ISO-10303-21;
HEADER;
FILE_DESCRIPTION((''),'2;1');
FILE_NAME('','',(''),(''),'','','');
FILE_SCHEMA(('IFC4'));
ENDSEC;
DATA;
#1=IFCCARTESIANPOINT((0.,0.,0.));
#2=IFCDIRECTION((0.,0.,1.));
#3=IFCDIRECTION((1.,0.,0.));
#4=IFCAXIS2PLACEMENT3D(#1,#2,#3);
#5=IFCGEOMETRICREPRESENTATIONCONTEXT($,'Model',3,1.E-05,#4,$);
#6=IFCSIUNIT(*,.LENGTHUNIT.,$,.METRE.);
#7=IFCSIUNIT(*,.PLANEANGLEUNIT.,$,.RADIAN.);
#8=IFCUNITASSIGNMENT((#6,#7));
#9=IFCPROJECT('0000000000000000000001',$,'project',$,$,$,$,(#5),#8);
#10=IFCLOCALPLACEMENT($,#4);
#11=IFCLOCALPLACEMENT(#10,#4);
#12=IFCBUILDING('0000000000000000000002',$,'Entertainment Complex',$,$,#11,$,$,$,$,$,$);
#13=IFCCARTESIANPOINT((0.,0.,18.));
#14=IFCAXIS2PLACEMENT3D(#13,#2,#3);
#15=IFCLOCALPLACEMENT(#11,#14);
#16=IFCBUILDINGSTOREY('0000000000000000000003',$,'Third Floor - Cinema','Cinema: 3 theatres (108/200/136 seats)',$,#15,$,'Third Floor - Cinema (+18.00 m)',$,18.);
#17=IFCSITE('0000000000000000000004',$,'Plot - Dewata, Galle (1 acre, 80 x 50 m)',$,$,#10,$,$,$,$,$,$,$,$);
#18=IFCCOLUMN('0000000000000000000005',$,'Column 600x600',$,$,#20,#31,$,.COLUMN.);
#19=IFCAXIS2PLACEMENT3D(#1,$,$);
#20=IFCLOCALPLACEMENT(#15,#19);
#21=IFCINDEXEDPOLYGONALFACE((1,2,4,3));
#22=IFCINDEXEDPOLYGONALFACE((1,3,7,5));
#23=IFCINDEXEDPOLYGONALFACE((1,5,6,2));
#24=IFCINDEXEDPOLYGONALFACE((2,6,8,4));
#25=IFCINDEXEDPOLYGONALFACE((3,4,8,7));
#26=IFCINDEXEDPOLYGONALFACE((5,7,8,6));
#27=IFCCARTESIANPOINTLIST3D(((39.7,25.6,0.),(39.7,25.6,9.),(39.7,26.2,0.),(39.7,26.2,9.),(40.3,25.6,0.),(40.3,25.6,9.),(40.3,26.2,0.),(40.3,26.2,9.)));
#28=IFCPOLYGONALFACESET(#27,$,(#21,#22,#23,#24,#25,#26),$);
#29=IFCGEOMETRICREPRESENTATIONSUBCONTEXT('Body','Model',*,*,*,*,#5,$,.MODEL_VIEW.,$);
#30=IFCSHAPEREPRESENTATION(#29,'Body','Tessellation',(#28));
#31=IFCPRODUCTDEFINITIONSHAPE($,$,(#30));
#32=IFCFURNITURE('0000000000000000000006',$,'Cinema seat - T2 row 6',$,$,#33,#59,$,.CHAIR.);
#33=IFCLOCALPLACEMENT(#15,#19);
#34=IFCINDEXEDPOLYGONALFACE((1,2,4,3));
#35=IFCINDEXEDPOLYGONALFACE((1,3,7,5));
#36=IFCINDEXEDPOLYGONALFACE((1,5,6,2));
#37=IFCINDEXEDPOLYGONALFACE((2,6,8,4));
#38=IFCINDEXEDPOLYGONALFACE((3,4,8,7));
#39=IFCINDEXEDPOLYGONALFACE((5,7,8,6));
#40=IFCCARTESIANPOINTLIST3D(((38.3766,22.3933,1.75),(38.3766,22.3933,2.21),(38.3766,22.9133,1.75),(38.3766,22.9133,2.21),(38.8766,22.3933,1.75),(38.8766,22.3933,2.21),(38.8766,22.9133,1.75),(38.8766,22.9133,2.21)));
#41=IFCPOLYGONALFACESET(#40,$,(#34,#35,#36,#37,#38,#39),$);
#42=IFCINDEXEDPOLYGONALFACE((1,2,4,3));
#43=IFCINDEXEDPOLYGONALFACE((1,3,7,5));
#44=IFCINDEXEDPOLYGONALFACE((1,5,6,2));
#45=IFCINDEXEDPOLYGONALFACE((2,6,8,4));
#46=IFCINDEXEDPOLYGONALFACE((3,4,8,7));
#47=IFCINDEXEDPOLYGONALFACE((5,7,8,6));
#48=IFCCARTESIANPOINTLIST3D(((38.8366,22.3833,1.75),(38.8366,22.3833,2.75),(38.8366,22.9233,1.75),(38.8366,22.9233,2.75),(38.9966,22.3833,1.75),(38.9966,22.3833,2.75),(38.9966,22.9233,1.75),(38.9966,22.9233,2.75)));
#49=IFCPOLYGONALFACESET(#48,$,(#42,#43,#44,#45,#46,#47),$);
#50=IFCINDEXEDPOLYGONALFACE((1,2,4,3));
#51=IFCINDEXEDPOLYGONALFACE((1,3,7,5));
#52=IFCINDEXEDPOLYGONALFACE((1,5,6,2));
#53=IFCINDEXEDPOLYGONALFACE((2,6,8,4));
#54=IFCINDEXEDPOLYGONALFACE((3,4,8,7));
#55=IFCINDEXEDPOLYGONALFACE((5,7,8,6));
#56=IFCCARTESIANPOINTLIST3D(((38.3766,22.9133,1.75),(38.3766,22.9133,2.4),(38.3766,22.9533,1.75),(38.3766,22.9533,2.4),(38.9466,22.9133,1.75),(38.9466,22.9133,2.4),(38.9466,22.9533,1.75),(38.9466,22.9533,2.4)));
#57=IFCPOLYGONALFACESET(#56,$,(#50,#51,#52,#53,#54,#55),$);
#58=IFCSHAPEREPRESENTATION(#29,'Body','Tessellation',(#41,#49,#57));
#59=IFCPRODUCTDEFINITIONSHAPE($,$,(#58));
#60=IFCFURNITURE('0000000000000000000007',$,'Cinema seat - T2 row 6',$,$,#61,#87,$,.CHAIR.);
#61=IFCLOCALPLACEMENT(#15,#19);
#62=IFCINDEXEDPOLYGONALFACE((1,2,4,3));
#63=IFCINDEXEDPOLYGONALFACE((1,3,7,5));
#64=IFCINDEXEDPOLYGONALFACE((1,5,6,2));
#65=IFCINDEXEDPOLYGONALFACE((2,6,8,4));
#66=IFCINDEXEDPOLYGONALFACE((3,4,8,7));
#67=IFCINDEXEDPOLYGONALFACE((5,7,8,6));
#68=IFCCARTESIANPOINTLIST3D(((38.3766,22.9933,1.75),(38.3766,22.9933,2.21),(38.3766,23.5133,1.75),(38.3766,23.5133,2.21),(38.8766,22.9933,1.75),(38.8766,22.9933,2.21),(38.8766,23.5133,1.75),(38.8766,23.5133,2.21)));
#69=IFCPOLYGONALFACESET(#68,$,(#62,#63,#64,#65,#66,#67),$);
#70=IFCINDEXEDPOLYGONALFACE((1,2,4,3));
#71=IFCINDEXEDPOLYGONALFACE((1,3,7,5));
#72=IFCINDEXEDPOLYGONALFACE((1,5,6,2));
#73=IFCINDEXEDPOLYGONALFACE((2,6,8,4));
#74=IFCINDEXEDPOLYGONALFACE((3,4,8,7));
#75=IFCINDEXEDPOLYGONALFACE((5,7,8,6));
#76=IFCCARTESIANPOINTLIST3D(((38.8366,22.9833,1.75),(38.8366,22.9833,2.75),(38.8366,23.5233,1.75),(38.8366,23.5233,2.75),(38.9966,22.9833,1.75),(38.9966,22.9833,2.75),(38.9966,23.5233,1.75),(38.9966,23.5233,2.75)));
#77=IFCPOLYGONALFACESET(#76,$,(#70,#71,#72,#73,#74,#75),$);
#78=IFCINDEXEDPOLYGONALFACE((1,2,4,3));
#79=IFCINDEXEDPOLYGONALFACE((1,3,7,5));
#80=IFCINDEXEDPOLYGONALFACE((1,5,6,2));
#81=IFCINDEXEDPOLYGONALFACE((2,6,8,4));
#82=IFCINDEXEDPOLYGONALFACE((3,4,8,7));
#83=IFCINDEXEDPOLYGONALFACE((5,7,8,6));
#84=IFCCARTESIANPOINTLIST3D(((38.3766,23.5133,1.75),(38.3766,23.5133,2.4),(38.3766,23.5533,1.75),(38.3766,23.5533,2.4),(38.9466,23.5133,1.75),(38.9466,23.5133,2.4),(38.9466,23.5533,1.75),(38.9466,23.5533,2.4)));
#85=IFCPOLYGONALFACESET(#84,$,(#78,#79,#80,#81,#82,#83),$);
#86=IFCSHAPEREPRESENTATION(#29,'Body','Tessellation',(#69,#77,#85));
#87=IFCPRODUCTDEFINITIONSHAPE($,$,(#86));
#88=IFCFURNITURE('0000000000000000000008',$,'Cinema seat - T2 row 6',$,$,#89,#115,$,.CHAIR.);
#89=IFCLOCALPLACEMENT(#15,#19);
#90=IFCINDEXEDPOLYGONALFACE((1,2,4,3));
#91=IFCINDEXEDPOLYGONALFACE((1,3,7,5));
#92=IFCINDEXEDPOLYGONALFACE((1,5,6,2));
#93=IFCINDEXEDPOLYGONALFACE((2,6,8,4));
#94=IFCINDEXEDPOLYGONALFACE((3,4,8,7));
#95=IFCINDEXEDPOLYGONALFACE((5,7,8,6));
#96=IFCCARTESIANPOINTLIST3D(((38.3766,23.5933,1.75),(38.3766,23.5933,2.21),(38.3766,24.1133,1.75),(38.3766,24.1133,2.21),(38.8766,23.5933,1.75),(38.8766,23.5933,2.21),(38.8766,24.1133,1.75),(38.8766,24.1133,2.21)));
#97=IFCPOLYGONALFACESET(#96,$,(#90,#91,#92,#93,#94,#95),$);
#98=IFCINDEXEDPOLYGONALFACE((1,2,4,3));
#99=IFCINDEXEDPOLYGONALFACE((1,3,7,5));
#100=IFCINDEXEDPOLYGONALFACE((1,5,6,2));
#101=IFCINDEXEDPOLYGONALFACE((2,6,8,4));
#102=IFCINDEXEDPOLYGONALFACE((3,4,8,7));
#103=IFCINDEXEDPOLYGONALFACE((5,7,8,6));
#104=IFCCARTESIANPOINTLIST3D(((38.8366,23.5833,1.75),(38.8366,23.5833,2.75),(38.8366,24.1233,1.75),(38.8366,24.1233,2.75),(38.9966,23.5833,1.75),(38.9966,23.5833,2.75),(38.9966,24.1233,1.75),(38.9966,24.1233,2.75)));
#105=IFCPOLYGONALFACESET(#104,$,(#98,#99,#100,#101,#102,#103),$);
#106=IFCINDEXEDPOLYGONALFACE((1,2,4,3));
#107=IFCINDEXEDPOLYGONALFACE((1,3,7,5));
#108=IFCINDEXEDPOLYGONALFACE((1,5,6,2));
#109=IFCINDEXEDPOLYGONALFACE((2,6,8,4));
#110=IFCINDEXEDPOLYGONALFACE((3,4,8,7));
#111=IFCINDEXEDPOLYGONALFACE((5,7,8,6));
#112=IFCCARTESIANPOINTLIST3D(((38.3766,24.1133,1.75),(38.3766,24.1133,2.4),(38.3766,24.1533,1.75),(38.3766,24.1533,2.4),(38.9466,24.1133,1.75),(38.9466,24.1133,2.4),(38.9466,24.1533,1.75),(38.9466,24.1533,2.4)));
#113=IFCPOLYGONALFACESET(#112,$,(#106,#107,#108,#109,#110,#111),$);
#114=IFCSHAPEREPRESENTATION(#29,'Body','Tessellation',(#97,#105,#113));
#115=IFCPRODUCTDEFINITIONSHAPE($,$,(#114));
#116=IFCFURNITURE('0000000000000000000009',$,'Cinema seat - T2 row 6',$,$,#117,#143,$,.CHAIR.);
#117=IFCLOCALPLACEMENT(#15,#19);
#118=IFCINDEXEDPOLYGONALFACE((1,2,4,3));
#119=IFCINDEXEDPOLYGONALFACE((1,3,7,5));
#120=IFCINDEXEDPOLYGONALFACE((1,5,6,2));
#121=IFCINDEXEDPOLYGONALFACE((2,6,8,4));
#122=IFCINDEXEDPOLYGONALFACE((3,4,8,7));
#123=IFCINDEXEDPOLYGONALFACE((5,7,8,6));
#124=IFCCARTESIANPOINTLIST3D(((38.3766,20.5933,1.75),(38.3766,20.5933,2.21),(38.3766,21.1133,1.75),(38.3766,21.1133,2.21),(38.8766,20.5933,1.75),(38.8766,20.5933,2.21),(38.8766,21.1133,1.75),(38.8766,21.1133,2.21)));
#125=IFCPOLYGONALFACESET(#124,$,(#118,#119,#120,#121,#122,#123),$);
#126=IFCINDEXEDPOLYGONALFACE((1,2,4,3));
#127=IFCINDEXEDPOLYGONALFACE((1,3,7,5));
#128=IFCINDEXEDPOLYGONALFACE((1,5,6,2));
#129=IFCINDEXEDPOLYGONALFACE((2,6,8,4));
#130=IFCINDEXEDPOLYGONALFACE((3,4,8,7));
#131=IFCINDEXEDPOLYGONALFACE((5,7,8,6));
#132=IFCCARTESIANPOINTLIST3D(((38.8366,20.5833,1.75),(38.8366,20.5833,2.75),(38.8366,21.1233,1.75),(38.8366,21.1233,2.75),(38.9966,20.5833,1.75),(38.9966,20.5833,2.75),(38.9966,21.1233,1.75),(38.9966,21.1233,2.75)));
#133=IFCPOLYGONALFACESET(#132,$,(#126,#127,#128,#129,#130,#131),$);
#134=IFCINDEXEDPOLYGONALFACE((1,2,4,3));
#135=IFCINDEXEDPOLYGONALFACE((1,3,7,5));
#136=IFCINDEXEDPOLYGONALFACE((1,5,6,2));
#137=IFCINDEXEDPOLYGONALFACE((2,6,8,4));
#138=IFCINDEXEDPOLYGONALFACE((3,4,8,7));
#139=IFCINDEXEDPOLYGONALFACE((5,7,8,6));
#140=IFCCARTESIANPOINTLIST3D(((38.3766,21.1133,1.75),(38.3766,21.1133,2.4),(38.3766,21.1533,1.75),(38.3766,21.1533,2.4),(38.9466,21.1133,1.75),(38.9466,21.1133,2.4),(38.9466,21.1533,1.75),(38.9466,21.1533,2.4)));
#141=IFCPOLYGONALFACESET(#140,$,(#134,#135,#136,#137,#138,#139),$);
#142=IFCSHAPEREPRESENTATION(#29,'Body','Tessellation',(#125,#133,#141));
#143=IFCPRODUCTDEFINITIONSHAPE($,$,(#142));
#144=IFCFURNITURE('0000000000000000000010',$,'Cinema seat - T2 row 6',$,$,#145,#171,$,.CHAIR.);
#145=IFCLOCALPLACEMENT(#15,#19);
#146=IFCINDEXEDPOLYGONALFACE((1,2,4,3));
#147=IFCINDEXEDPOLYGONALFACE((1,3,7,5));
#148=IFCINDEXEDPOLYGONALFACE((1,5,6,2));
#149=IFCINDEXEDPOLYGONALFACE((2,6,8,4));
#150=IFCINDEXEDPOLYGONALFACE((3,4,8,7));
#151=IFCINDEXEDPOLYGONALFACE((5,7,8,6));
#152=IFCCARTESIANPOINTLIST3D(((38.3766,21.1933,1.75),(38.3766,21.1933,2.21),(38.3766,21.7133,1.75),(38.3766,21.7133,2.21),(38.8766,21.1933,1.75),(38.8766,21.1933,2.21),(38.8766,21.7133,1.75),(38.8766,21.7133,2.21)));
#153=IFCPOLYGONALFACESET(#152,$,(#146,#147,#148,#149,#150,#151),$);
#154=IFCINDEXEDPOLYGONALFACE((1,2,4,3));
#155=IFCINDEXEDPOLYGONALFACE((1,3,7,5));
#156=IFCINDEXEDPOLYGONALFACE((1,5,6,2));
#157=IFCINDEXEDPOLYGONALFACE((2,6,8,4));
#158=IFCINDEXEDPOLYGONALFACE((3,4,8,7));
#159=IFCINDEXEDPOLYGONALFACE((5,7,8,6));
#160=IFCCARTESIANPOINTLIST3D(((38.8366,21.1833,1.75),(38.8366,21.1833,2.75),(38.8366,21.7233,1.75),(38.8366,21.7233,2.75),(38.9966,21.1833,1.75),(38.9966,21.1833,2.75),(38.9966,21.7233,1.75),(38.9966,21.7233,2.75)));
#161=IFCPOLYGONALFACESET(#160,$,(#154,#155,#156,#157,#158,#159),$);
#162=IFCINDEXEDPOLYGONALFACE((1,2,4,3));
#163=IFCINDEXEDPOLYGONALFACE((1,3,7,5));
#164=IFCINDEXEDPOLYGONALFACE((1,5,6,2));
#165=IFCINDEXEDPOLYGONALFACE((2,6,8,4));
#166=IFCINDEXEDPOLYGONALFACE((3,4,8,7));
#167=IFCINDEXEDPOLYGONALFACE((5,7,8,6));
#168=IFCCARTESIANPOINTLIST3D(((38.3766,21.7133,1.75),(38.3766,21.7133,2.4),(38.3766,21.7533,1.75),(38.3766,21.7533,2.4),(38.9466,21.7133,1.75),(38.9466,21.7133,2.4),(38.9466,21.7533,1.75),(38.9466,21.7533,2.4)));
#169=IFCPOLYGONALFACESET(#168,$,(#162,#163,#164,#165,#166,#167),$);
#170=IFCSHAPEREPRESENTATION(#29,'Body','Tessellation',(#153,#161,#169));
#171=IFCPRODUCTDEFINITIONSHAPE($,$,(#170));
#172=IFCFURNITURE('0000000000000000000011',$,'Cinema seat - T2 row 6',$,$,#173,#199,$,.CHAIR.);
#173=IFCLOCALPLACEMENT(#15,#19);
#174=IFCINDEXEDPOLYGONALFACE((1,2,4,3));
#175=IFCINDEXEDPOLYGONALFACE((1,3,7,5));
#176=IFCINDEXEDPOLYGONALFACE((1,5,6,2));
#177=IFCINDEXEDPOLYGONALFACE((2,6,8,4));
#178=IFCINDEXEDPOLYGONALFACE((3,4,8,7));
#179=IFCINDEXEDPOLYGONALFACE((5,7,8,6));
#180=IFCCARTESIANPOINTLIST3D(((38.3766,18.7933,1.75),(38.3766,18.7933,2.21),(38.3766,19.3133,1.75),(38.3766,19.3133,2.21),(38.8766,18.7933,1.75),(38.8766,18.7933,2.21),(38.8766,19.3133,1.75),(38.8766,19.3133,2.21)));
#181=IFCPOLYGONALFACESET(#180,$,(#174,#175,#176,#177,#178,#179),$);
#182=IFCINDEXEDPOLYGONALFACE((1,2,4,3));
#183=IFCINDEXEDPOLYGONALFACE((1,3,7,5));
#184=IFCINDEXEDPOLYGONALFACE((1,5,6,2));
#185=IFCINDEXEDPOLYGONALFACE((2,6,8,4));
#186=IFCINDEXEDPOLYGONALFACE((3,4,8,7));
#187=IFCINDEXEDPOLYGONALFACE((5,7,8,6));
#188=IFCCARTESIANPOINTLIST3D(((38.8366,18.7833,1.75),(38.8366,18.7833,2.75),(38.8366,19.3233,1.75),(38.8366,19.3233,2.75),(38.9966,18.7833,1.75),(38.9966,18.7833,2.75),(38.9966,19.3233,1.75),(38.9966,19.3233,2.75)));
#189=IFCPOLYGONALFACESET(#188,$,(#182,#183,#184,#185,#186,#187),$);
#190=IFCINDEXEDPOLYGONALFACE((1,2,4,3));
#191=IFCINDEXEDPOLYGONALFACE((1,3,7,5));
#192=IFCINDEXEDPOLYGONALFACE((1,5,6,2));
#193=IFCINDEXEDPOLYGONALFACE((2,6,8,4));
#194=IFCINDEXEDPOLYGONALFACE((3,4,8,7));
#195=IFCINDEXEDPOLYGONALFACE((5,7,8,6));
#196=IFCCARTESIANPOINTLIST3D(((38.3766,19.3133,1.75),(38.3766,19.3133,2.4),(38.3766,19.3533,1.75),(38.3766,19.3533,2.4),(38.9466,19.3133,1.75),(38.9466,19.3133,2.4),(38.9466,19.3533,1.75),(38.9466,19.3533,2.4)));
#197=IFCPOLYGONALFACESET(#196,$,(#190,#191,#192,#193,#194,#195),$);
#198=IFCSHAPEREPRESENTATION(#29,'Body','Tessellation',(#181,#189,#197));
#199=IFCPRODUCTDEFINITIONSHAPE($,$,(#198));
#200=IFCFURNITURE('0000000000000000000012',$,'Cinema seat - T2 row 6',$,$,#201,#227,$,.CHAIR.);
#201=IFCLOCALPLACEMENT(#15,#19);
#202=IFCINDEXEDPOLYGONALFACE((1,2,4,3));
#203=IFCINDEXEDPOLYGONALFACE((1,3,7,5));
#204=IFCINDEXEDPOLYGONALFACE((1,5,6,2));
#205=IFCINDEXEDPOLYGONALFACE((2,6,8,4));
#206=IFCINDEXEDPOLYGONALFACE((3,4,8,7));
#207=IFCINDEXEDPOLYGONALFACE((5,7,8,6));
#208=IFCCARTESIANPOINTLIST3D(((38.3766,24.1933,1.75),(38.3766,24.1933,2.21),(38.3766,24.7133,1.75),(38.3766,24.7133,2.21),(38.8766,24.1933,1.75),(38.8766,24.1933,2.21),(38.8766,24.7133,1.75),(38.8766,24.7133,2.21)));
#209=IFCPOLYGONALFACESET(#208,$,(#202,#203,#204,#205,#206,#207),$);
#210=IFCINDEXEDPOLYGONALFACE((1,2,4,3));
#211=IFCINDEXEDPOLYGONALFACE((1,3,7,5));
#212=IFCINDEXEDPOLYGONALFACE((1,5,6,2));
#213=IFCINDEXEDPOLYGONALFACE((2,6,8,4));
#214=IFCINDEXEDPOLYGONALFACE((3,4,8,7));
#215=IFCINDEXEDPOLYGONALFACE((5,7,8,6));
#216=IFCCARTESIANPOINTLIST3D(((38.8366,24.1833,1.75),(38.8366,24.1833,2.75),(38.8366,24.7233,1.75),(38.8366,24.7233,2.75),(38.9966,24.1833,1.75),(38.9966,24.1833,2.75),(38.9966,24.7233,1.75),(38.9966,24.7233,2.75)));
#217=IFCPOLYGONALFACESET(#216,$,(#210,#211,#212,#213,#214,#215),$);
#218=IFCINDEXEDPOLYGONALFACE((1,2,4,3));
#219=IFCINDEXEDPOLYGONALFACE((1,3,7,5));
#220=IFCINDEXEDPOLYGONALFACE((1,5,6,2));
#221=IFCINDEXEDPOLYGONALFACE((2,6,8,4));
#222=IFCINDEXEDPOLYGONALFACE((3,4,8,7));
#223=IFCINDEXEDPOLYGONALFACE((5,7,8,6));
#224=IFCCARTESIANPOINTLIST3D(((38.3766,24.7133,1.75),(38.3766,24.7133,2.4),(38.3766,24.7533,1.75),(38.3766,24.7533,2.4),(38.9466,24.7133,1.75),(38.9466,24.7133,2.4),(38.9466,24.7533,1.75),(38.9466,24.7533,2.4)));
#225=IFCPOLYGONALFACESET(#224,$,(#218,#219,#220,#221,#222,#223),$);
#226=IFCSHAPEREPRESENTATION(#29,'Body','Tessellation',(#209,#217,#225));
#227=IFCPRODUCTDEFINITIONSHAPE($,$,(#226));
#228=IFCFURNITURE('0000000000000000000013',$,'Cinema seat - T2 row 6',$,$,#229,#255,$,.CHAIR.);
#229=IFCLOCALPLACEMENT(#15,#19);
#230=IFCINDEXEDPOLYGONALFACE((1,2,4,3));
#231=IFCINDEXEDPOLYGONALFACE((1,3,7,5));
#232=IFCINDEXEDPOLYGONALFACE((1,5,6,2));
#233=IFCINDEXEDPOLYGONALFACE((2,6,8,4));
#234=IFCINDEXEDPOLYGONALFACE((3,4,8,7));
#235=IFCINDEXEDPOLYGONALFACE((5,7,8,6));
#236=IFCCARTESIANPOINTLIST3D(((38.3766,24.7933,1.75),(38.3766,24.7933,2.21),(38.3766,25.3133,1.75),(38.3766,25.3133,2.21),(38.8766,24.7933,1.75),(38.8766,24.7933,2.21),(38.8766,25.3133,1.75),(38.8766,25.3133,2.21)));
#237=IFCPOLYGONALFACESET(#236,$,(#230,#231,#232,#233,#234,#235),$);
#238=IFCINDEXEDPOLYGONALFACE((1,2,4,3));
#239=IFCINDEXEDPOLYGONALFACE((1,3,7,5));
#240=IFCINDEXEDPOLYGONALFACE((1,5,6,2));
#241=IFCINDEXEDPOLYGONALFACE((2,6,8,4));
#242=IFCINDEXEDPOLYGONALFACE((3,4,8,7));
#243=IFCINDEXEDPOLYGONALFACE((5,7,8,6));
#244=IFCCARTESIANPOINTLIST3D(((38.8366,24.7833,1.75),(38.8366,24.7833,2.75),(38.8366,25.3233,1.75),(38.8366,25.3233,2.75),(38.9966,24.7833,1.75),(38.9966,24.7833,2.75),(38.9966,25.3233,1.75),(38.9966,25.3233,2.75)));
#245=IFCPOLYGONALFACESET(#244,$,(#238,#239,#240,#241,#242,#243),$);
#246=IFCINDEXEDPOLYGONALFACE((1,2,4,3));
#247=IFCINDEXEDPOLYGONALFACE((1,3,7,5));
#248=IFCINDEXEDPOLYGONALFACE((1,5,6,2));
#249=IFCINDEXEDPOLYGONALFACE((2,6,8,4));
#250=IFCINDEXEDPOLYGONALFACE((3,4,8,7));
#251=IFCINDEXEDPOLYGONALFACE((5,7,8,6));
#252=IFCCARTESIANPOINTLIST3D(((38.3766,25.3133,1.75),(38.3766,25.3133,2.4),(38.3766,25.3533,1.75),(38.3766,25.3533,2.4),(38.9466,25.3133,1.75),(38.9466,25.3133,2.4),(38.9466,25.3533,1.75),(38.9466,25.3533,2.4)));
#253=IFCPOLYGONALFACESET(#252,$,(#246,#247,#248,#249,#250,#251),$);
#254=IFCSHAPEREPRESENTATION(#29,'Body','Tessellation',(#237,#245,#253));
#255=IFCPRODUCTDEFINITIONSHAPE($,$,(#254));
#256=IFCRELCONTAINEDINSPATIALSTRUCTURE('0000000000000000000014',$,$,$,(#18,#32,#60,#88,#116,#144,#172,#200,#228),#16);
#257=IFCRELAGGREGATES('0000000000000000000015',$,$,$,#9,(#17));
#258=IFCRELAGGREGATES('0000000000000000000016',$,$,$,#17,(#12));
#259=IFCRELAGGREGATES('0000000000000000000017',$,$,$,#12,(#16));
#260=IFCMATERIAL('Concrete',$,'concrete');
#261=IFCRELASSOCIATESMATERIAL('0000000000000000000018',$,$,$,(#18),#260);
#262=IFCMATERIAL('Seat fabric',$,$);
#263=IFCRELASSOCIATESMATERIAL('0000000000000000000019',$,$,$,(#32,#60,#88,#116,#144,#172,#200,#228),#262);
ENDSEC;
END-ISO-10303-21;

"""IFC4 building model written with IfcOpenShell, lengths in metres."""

from ifc_helpers import new_model, si_unit, frame, origin_with_axes, place, context, subcontext, project, spatial, polyline, outline, extrude, material, element, save


model = new_model("IFC4")

# Units and contexts
model_context = context("Model", 3, precision=1e-05, world=origin_with_axes())
body_context = subcontext(model_context, "Body", "Model", "MODEL_VIEW")
ifc_project = project(units=[si_unit("LENGTHUNIT", "METRE"), si_unit("PLANEANGLEUNIT", "RADIAN")], contexts=[model_context])

# Site, building, storey
site_placement = place(None, origin_with_axes())
site = spatial("IfcSite", under=ifc_project, at=site_placement, Name="Plot - Dewata, Galle (1 acre, 80 x 50 m)")
building_placement = place(site_placement, origin_with_axes())
building = spatial("IfcBuilding", under=site, at=building_placement, Name="Entertainment Complex")
storey_placement = place(building_placement, frame((0.0, 0.0, 18.0), z_axis=(0.0, 0.0, 1.0), x_axis=(1.0, 0.0, 0.0)))
storey = spatial("IfcBuildingStorey", under=building, at=storey_placement, Name="Third Floor - Cinema", Description="Cinema: 3 theatres (108/200/136 seats)", LongName="Third Floor - Cinema (+18.00 m)", Elevation=18.0)

# Column
ifc_material_1 = material(Name="Concrete", Category="concrete")
column_placement = place(storey_placement, frame((40.0, 25.9, 0.0), z_axis=(0.0, 0.0, 1.0), x_axis=(1.0, 0.0, 0.0)))
element("IfcColumn", 1, at=column_placement, inside=storey, material=ifc_material_1, Name="Column 600x600", PredefinedType="COLUMN", context=body_context, shape_type="SweptSolid", body=[
    extrude(outline(polyline([(-0.3, -0.3), (0.3, -0.3), (0.3, 0.3), (-0.3, 0.3), (-0.3, -0.3)])), origin_with_axes(), (0.0, 0.0, 1.0), 9.0),
])

# Furniture
ifc_material_2 = material(Name="Seat fabric")
for number, where, z_axis, x_axis, name in (
    (2, (38.9966, 22.6533, 1.75), (0.0, 0.0, 1.0), (1.0, 0.0, 0.0), "Cinema seat - T2 row 6"),
    (3, (38.9966, 23.2533, 1.75), (0.0, 0.0, 1.0), (1.0, 0.0, 0.0), "Cinema seat - T2 row 6"),
    (4, (38.9966, 23.8533, 1.75), (0.0, 0.0, 1.0), (1.0, 0.0, 0.0), "Cinema seat - T2 row 6"),
    (5, (38.9966, 20.8533, 1.75), (0.0, 0.0, 1.0), (1.0, 0.0, 0.0), "Cinema seat - T2 row 6"),
    (6, (38.9966, 21.4533, 1.75), (0.0, 0.0, 1.0), (1.0, 0.0, 0.0), "Cinema seat - T2 row 6"),
    (7, (38.9966, 19.0533, 1.75), (0.0, 0.0, 1.0), (1.0, 0.0, 0.0), "Cinema seat - T2 row 6"),
    (8, (38.9966, 24.4533, 1.75), (0.0, 0.0, 1.0), (1.0, 0.0, 0.0), "Cinema seat - T2 row 6"),
    (9, (38.9966, 25.0533, 1.75), (0.0, 0.0, 1.0), (1.0, 0.0, 0.0), "Cinema seat - T2 row 6"),
):
    element("IfcFurniture", number, at=place(storey_placement, frame(where, z_axis=z_axis, x_axis=x_axis)), inside=storey, material=ifc_material_2, Name=name, PredefinedType="CHAIR", context=body_context, shape_type="SweptSolid", body=[
        extrude(outline(polyline([(-0.62, -0.26), (-0.12, -0.26), (-0.12, 0.26), (-0.62, 0.26), (-0.62, -0.26)])), origin_with_axes(), (0.0, 0.0, 1.0), 0.46),
        extrude(outline(polyline([(-0.16, -0.27), (0.0, -0.27), (0.0, 0.27), (-0.16, 0.27), (-0.16, -0.27)])), origin_with_axes(), (0.0, 0.0, 1.0), 1.0),
        extrude(outline(polyline([(-0.62, 0.26), (-0.05, 0.26), (-0.05, 0.3), (-0.62, 0.3), (-0.62, 0.26)])), origin_with_axes(), (0.0, 0.0, 1.0), 0.65),
    ])

save(model, "model.ifc")
